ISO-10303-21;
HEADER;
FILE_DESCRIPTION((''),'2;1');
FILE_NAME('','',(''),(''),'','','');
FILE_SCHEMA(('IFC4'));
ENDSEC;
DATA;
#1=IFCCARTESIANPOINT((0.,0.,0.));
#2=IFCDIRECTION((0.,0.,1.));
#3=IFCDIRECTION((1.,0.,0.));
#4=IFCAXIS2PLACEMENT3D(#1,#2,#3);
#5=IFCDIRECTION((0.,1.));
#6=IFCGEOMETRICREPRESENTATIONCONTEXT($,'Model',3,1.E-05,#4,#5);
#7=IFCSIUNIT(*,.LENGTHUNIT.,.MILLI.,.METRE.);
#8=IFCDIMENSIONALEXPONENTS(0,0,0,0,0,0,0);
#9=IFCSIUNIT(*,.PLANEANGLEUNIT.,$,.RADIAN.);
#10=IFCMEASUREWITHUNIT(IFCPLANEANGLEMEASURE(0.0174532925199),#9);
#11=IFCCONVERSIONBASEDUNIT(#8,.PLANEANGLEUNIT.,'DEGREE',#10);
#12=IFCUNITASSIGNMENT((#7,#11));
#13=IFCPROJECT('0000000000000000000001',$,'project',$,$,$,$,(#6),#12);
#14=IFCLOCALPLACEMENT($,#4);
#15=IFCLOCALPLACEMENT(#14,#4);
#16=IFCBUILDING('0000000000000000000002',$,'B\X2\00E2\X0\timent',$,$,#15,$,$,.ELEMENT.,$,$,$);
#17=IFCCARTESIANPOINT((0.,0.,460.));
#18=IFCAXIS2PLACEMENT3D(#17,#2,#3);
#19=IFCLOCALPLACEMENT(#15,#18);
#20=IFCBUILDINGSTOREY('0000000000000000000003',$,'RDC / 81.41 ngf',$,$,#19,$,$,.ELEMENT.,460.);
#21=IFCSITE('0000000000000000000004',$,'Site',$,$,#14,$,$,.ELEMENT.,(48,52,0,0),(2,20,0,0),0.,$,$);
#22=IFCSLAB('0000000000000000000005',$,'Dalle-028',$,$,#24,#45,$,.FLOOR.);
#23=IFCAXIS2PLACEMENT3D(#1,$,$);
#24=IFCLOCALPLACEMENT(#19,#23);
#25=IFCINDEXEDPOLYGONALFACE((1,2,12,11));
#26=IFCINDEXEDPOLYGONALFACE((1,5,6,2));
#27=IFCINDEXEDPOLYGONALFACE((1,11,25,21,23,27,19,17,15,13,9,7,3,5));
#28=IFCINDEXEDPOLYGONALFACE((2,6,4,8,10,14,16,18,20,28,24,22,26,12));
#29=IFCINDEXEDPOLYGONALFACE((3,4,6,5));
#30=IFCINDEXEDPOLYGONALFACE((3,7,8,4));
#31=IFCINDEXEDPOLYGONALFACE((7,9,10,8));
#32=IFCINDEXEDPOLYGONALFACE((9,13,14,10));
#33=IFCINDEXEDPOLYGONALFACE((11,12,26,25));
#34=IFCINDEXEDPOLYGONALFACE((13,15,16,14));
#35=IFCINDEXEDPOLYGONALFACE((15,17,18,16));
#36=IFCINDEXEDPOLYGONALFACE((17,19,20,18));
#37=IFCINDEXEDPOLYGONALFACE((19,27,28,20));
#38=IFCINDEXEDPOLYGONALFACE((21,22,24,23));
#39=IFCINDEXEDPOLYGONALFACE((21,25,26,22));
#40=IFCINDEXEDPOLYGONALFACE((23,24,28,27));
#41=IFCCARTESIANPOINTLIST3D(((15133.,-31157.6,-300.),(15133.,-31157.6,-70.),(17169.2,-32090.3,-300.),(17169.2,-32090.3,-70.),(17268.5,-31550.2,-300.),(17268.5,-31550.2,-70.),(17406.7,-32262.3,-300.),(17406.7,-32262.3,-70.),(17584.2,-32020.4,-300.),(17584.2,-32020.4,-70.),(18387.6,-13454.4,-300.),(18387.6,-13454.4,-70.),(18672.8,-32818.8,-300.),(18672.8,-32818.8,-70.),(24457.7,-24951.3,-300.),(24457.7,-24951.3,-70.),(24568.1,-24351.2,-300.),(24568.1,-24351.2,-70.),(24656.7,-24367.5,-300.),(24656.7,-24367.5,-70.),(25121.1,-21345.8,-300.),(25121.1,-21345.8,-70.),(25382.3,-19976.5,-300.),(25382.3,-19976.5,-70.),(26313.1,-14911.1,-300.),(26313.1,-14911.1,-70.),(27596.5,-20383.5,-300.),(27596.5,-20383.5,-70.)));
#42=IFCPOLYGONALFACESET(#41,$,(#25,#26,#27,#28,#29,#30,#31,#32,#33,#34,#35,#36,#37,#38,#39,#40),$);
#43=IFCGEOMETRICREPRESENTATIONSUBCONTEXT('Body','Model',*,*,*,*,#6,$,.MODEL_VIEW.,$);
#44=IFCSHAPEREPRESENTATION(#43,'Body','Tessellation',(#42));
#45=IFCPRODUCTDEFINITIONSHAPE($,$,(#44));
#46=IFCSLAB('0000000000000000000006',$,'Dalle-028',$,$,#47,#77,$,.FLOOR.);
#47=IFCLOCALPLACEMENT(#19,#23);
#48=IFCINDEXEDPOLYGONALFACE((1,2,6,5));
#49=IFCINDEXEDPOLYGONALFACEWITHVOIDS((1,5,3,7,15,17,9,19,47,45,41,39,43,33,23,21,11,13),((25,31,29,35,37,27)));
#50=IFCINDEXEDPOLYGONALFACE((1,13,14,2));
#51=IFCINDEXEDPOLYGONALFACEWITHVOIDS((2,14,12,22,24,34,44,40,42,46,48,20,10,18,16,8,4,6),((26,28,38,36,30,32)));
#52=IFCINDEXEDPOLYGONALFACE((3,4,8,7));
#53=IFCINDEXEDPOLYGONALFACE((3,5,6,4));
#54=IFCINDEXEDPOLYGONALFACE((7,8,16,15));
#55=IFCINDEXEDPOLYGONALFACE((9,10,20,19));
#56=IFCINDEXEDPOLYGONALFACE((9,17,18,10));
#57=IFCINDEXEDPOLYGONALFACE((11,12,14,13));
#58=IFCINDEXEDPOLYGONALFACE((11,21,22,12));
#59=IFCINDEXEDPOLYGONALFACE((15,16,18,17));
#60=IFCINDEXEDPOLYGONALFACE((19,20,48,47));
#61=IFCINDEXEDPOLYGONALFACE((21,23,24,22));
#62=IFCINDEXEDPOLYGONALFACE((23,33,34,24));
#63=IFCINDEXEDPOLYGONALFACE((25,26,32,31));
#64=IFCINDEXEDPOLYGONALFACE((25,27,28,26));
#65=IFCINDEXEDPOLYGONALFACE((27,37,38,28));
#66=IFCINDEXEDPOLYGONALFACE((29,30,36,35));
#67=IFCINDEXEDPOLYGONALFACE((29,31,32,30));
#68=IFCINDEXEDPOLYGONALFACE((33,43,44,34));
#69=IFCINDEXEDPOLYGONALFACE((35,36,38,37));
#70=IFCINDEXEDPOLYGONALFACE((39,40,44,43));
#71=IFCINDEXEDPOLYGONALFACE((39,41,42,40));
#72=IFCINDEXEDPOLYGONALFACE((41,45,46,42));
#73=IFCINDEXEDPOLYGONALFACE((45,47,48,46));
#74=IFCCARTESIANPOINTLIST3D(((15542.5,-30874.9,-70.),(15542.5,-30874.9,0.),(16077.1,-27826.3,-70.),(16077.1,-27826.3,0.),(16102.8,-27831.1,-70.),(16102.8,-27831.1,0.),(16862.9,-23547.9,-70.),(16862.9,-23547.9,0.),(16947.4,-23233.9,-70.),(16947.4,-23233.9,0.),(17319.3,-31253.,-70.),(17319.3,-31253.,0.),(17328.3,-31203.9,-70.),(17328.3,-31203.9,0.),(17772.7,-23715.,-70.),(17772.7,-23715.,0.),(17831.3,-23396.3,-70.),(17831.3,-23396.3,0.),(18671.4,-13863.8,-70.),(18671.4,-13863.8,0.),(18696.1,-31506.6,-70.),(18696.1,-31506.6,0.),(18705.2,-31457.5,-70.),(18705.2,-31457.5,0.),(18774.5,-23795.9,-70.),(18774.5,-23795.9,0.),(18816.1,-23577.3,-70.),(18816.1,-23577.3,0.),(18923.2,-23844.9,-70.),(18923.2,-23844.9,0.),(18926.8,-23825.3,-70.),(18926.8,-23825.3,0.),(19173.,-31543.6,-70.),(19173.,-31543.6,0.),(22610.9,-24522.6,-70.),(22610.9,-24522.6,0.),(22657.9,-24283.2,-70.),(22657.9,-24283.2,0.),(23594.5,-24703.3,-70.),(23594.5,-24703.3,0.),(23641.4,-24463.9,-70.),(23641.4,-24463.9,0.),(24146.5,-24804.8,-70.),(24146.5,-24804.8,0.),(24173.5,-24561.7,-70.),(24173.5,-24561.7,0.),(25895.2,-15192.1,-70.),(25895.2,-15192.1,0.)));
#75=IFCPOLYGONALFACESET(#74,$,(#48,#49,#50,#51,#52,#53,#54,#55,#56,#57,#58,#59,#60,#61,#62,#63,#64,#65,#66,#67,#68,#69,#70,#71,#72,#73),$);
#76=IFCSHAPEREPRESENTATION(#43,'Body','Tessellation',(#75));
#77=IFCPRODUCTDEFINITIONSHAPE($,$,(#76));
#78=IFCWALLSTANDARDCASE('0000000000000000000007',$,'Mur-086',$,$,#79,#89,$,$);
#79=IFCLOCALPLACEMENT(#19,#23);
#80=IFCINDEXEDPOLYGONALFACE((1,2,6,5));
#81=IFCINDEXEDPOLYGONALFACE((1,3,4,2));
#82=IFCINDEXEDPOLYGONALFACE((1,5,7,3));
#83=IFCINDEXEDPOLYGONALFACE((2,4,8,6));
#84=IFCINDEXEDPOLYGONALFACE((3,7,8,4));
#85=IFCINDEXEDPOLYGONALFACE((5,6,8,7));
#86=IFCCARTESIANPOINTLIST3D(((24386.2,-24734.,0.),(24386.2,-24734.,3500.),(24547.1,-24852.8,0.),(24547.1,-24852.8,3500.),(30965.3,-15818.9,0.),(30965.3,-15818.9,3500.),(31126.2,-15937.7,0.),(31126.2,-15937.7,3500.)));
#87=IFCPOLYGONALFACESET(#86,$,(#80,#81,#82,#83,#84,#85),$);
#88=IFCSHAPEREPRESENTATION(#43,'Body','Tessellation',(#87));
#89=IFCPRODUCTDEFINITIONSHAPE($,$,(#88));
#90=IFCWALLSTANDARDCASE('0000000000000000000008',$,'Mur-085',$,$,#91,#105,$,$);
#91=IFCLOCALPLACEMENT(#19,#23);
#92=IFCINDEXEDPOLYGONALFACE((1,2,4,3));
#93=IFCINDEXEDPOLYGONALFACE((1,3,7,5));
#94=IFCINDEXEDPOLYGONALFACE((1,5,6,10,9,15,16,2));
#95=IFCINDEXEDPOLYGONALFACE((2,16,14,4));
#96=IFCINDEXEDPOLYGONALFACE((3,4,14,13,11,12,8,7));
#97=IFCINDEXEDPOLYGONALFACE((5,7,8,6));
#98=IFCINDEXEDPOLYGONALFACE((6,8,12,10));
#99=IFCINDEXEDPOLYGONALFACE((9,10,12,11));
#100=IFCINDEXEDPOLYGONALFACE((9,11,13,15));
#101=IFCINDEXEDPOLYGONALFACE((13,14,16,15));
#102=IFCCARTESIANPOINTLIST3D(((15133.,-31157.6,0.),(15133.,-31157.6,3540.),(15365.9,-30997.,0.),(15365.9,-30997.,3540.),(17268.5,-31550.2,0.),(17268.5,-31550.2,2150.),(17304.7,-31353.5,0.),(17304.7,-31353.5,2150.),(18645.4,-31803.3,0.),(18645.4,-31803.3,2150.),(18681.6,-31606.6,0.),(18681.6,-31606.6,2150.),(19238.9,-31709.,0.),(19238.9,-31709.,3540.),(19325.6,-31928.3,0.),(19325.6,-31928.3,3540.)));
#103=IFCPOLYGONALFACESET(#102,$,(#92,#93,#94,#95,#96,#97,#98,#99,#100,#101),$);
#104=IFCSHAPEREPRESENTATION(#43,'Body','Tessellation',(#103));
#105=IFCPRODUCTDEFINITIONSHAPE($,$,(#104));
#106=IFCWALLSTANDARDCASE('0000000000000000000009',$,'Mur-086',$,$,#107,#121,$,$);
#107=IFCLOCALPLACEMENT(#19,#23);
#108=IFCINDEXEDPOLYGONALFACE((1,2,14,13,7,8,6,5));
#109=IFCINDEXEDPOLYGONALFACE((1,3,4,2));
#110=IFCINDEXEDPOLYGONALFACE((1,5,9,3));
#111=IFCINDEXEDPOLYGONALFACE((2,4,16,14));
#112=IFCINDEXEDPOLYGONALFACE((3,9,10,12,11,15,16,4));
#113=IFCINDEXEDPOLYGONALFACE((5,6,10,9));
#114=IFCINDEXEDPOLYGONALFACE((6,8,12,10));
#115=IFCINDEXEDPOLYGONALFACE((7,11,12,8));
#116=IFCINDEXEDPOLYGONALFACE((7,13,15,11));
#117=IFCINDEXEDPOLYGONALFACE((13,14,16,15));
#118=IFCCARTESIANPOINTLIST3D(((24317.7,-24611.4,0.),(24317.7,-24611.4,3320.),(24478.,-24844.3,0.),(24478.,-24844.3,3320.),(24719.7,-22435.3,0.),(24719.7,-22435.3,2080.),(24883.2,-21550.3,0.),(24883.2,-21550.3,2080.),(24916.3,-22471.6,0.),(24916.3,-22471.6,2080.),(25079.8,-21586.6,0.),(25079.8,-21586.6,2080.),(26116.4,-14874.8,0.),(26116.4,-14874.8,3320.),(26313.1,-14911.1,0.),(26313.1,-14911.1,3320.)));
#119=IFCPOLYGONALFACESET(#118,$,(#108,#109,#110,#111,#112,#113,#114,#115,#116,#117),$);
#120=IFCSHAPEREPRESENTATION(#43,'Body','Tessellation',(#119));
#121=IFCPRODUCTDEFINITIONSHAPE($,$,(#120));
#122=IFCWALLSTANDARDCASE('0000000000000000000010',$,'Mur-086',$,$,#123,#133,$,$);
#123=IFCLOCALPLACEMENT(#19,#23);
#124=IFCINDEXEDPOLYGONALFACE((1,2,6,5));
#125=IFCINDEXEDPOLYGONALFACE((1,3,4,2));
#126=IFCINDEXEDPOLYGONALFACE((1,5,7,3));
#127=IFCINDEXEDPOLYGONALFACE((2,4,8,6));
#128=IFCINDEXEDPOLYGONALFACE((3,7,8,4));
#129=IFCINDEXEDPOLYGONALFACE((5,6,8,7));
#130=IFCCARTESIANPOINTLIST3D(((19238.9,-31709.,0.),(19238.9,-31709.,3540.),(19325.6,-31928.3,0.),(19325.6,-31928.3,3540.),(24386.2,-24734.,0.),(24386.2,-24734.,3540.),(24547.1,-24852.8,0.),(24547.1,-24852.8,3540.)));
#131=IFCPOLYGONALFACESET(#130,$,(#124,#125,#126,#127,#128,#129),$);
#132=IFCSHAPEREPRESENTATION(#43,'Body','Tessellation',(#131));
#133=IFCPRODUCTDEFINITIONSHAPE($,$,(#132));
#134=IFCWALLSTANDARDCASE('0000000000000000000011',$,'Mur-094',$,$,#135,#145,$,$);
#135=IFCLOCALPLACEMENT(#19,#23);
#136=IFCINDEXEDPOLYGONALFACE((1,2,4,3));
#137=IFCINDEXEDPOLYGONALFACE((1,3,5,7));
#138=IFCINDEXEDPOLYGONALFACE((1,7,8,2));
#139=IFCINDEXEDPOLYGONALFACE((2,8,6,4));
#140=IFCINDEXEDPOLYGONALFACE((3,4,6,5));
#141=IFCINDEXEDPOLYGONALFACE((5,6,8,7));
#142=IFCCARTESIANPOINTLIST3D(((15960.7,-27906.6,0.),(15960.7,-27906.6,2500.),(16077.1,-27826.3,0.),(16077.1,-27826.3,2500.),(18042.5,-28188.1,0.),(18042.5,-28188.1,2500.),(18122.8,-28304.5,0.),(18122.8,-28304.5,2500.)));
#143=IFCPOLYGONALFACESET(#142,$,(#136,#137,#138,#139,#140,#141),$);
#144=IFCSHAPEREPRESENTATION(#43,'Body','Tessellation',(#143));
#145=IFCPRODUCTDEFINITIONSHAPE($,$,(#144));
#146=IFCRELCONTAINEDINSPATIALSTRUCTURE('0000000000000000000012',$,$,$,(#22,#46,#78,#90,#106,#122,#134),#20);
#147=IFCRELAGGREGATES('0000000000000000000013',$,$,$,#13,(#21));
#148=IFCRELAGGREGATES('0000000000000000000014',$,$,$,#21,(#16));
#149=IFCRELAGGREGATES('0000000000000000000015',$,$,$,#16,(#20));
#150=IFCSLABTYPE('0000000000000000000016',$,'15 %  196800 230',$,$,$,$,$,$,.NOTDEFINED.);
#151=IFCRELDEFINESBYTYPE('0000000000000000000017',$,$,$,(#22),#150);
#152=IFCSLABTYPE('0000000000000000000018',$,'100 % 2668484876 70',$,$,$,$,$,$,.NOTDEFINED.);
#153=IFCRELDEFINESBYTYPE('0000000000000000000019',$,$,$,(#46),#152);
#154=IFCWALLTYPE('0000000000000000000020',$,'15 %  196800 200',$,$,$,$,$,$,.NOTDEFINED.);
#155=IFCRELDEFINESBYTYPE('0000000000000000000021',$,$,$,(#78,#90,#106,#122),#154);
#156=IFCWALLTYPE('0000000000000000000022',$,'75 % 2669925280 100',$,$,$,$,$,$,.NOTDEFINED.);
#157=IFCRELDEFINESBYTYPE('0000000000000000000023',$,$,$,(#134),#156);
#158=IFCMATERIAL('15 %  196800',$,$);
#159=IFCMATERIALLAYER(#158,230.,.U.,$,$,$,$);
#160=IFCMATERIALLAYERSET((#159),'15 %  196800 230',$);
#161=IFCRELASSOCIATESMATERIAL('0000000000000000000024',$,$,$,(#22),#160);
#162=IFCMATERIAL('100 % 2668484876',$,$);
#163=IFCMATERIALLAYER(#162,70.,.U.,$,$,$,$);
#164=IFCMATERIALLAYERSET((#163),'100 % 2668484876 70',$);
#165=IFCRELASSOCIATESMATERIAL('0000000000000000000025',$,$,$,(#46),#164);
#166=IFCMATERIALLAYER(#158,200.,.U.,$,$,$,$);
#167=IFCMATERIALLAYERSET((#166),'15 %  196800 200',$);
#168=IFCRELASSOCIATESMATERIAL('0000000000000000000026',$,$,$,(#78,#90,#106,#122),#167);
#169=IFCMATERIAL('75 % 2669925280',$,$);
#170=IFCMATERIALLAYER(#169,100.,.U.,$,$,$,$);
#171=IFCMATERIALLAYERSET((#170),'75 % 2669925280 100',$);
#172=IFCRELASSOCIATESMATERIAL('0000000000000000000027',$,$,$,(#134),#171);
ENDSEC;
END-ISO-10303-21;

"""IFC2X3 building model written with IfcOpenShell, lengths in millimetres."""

from ifc_helpers import new_model, entity, si_unit, converted_unit, direction, frame, origin_with_axes, origin_2d_with_axis, place, context, subcontext, project, spatial, polyline, rectangle, outline, extrude, material, layer, layer_set, layer_usage, type_object, element, save


model = new_model("IFC2X3")

# Units and contexts
model_context = context("Model", 3, precision=1e-05, world=origin_with_axes(), true_north=direction((0.0, 1.0)))
body_context = subcontext(model_context, "Body", "Model", "MODEL_VIEW")
ifc_project = project(units=[si_unit("LENGTHUNIT", "METRE", prefix="MILLI"), converted_unit("PLANEANGLEUNIT", "DEGREE", entity("IfcPlaneAngleMeasure", 0.0174532925199), si_unit("PLANEANGLEUNIT", "RADIAN"), dimensions=[0, 0, 0, 0, 0, 0, 0])], contexts=[model_context])

# Site, building, storey
site_placement = place(None, origin_with_axes())
site = spatial("IfcSite", under=ifc_project, at=site_placement, Name="Site", CompositionType="ELEMENT", RefLatitude=(48, 52, 0, 0), RefLongitude=(2, 20, 0, 0), RefElevation=0.0)
building_placement = place(site_placement, origin_with_axes())
building = spatial("IfcBuilding", under=site, at=building_placement, Name="Bâtiment", CompositionType="ELEMENT")
storey_placement = place(building_placement, frame((0.0, 0.0, 460.0), z_axis=(0.0, 0.0, 1.0), x_axis=(1.0, 0.0, 0.0)))
storey = spatial("IfcBuildingStorey", under=building, at=storey_placement, Name="RDC / 81.41 ngf", CompositionType="ELEMENT", Elevation=460.0)

# Slab
ifc_material_1 = material(Name="15 %  196800")
ifc_layer_1 = layer(ifc_material_1, 230.0, ventilated="UNKNOWN")
ifc_layer_set_1 = layer_set([ifc_layer_1], Name="15 %  196800 230")
ifc_layer_usage_1 = layer_usage(ifc_layer_set_1, "AXIS3", "NEGATIVE", 230.0)
slab_type_1 = type_object("IfcSlabType", Name="15 %  196800 230", PredefinedType="NOTDEFINED")
slab_1_placement = place(storey_placement, frame((15133.0, -31157.6, -70.0), z_axis=(0.0, 0.0, 1.0), x_axis=(1.0, 0.0, 0.0)))
element("IfcSlab", 1, at=slab_1_placement, inside=storey, type_object=slab_type_1, material=ifc_layer_usage_1, Name="Dalle-028", PredefinedType="FLOOR", context=body_context, shape_type="SweptSolid", body=[
    extrude(outline(polyline([(0.0, 0.0), (2135.5, -392.6), (2036.2, -932.8), (2273.7, -1104.7), (2451.1, -862.8), (3539.7, -1661.2), (9324.6, 6206.3), (9435.1, 6806.4), (9523.7, 6790.1), (12463.4, 10774.1), (10249.2, 11181.0), (9988.0, 9811.8), (11180.0, 16246.5), (3254.5, 17703.2), (0.0, 0.0)])), frame((0.0, 0.0, -230.0), z_axis=(0.0, 0.0, 1.0), x_axis=(1.0, 0.0, 0.0)), (0.0, 0.0, 1.0), 230.0),
])

# Slab, opening
ifc_material_2 = material(Name="100 % 2668484876")
ifc_layer_2 = layer(ifc_material_2, 70.0, ventilated="UNKNOWN")
ifc_layer_set_2 = layer_set([ifc_layer_2], Name="100 % 2668484876 70")
ifc_layer_usage_2 = layer_usage(ifc_layer_set_2, "AXIS3", "NEGATIVE", 70.0)
slab_type_2 = type_object("IfcSlabType", Name="100 % 2668484876 70", PredefinedType="NOTDEFINED")
slab_2_placement = place(storey_placement, frame((15542.5, -30874.9, 0.0), z_axis=(0.0, 0.0, 1.0), x_axis=(1.0, 0.0, 0.0)))
slab_2 = element("IfcSlab", 2, at=slab_2_placement, inside=storey, type_object=slab_type_2, material=ifc_layer_usage_2, Name="Dalle-028", PredefinedType="FLOOR", context=body_context, shape_type="SweptSolid", body=[
    extrude(outline(polyline([(0.0, 0.0), (1785.8, -328.9), (1776.8, -378.1), (3153.6, -631.7), (3162.6, -582.5), (3630.4, -668.7), (8604.0, 6070.2), (8051.9, 6171.6), (8098.9, 6411.0), (8631.0, 6313.2), (10352.7, 15682.8), (3128.9, 17011.2), (1404.9, 7641.0), (2288.7, 7478.6), (2230.2, 7159.9), (1320.4, 7327.0), (534.6, 3048.6), (560.3, 3043.9), (0.0, 0.0)])), frame((0.0, 0.0, -70.0), z_axis=(0.0, 0.0, 1.0), x_axis=(1.0, 0.0, 0.0)), (0.0, 0.0, 1.0), 70.0),
])
opening_1_placement = place(slab_2_placement, origin_with_axes())
element("IfcOpeningElement", 3, at=opening_1_placement, cuts=slab_2, context=body_context, shape_type="SweptSolid", body=[
    extrude(outline(polyline([(3232.0, 7079.0), (3384.3, 7049.7), (3380.6, 7030.0), (7068.4, 6352.3), (7115.4, 6591.7), (3273.6, 7297.7), (3232.0, 7079.0)])), frame((0.0, 0.0, -70.0), z_axis=(0.0, 0.0, 1.0), x_axis=(1.0, 0.0, 0.0)), (0.0, 0.0, 1.0), 70.0),
])

# Wall
ifc_layer_3 = layer(ifc_material_1, 200.0, ventilated="UNKNOWN")
ifc_layer_set_3 = layer_set([ifc_layer_3], Name="15 %  196800 200")
ifc_layer_usage_3 = layer_usage(ifc_layer_set_3, "AXIS2", "POSITIVE", 0.0)
wall_type_1 = type_object("IfcWallType", Name="15 %  196800 200", PredefinedType="NOTDEFINED")
wall_1_placement = place(storey_placement, frame((24547.1, -24852.8, 0.0), z_axis=(0.0, 0.0, 1.0), x_axis=(0.593784, 0.804624, 0.0)))
element("IfcWallStandardCase", 4, at=wall_1_placement, inside=storey, type_object=wall_type_1, material=ifc_layer_usage_3, Name="Mur-086", context=body_context, shape_type="SweptSolid", body=[
    extrude(outline(polyline([(0.0, 0.0), (11079.9, 0.0), (11079.9, 200.0), (0.0, 200.0), (0.0, 0.0)])), origin_with_axes(), (0.0, 0.0, 1.0), 3500.0),
])

# Walls, openings
ifc_layer_usage_4 = layer_usage(ifc_layer_set_3, "AXIS2", "POSITIVE", 0.0)
wall_2_placement = place(storey_placement, frame((15133.0, -31157.6, 0.0), z_axis=(0.0, 0.0, 1.0), x_axis=(0.98352, -0.180802, 0.0)))
wall_2 = element("IfcWallStandardCase", 5, at=wall_2_placement, inside=storey, type_object=wall_type_1, material=ifc_layer_usage_4, Name="Mur-085", context=body_context, shape_type="SweptSolid", body=[
    extrude(outline(polyline([(0.0, 0.0), (4262.9, 0.0), (4137.9, 200.0), (200.0, 200.0), (0.0, 0.0)])), origin_with_axes(), (0.0, 0.0, 1.0), 3540.0),
])
opening_2_placement = place(wall_2_placement, frame((2871.3, 0.0, 0.0), z_axis=(0.0, 0.0, 1.0), x_axis=(1.0, 0.0, 0.0)))
element("IfcOpeningElement", 6, at=opening_2_placement, cuts=wall_2, context=body_context, shape_type="SweptSolid", body=[
    extrude(rectangle(XDim=1400.0, YDim=2150.0, at=origin_2d_with_axis()), frame((0.0, -200.0, 1075.0), z_axis=(0.0, -1.0, 0.0), x_axis=(1.0, 0.0, 0.0)), (0.0, 0.0, -1.0), 600.0),
])
ifc_layer_usage_5 = layer_usage(ifc_layer_set_3, "AXIS2", "POSITIVE", 0.0)
wall_3_placement = place(storey_placement, frame((24514.4, -24647.6, 0.0), z_axis=(0.0, 0.0, 1.0), x_axis=(0.181664, 0.983361, 0.0)))
wall_3 = element("IfcWallStandardCase", 7, at=wall_3_placement, inside=storey, type_object=wall_type_1, material=ifc_layer_usage_5, Name="Mur-086", context=body_context, shape_type="SweptSolid", body=[
    extrude(outline(polyline([(-200.0, 0.0), (9901.2, 0.0), (9901.2, 200.0), (-0.1, 200.0), (-200.0, 0.0)])), origin_with_axes(), (0.0, 0.0, 1.0), 3320.0),
])
opening_3_placement = place(wall_3_placement, frame((2662.8, 0.0, 0.0), z_axis=(0.0, 0.0, 1.0), x_axis=(1.0, 0.0, 0.0)))
element("IfcOpeningElement", 8, at=opening_3_placement, cuts=wall_3, context=body_context, shape_type="SweptSolid", body=[
    extrude(rectangle(XDim=900.0, YDim=2080.0, at=origin_2d_with_axis()), frame((0.0, 400.0, 1040.0), z_axis=(0.0, -1.0, 0.0), x_axis=(1.0, 0.0, 0.0)), (0.0, 0.0, 1.0), 600.0),
])

# Walls
ifc_layer_usage_6 = layer_usage(ifc_layer_set_3, "AXIS2", "POSITIVE", 0.0)
wall_4_placement = place(storey_placement, frame((19325.6, -31928.3, 0.0), z_axis=(0.0, 0.0, 1.0), x_axis=(0.593784, 0.804624, 0.0)))
element("IfcWallStandardCase", 9, at=wall_4_placement, inside=storey, type_object=wall_type_1, material=ifc_layer_usage_6, Name="Mur-086", context=body_context, shape_type="SweptSolid", body=[
    extrude(outline(polyline([(0.0, 0.0), (8793.6, 0.0), (8793.6, 200.0), (125.0, 200.0), (0.0, 0.0)])), origin_with_axes(), (0.0, 0.0, 1.0), 3540.0),
])
ifc_material_3 = material(Name="75 % 2669925280")
ifc_layer_4 = layer(ifc_material_3, 100.0, ventilated="UNKNOWN")
ifc_layer_set_4 = layer_set([ifc_layer_4], Name="75 % 2669925280 100")
ifc_layer_usage_7 = layer_usage(ifc_layer_set_4, "AXIS2", "NEGATIVE", 100.0)
wall_type_2 = type_object("IfcWallType", Name="75 % 2669925280 100", PredefinedType="NOTDEFINED")
wall_5_placement = place(storey_placement, frame((18042.5, -28188.1, 0.0), z_axis=(0.0, 0.0, 1.0), x_axis=(-0.983484, 0.180998, 0.0)))
element("IfcWallStandardCase", 10, at=wall_5_placement, inside=storey, type_object=wall_type_2, material=ifc_layer_usage_7, Name="Mur-094", context=body_context, shape_type="SweptSolid", body=[
    extrude(outline(polyline([(0.0, 0.0), (1998.4, 0.0), (2098.4, 100.0), (-100.0, 100.0), (0.0, 0.0)])), origin_with_axes(), (0.0, 0.0, 1.0), 2500.0),
])

save(model, "model.ifc")
